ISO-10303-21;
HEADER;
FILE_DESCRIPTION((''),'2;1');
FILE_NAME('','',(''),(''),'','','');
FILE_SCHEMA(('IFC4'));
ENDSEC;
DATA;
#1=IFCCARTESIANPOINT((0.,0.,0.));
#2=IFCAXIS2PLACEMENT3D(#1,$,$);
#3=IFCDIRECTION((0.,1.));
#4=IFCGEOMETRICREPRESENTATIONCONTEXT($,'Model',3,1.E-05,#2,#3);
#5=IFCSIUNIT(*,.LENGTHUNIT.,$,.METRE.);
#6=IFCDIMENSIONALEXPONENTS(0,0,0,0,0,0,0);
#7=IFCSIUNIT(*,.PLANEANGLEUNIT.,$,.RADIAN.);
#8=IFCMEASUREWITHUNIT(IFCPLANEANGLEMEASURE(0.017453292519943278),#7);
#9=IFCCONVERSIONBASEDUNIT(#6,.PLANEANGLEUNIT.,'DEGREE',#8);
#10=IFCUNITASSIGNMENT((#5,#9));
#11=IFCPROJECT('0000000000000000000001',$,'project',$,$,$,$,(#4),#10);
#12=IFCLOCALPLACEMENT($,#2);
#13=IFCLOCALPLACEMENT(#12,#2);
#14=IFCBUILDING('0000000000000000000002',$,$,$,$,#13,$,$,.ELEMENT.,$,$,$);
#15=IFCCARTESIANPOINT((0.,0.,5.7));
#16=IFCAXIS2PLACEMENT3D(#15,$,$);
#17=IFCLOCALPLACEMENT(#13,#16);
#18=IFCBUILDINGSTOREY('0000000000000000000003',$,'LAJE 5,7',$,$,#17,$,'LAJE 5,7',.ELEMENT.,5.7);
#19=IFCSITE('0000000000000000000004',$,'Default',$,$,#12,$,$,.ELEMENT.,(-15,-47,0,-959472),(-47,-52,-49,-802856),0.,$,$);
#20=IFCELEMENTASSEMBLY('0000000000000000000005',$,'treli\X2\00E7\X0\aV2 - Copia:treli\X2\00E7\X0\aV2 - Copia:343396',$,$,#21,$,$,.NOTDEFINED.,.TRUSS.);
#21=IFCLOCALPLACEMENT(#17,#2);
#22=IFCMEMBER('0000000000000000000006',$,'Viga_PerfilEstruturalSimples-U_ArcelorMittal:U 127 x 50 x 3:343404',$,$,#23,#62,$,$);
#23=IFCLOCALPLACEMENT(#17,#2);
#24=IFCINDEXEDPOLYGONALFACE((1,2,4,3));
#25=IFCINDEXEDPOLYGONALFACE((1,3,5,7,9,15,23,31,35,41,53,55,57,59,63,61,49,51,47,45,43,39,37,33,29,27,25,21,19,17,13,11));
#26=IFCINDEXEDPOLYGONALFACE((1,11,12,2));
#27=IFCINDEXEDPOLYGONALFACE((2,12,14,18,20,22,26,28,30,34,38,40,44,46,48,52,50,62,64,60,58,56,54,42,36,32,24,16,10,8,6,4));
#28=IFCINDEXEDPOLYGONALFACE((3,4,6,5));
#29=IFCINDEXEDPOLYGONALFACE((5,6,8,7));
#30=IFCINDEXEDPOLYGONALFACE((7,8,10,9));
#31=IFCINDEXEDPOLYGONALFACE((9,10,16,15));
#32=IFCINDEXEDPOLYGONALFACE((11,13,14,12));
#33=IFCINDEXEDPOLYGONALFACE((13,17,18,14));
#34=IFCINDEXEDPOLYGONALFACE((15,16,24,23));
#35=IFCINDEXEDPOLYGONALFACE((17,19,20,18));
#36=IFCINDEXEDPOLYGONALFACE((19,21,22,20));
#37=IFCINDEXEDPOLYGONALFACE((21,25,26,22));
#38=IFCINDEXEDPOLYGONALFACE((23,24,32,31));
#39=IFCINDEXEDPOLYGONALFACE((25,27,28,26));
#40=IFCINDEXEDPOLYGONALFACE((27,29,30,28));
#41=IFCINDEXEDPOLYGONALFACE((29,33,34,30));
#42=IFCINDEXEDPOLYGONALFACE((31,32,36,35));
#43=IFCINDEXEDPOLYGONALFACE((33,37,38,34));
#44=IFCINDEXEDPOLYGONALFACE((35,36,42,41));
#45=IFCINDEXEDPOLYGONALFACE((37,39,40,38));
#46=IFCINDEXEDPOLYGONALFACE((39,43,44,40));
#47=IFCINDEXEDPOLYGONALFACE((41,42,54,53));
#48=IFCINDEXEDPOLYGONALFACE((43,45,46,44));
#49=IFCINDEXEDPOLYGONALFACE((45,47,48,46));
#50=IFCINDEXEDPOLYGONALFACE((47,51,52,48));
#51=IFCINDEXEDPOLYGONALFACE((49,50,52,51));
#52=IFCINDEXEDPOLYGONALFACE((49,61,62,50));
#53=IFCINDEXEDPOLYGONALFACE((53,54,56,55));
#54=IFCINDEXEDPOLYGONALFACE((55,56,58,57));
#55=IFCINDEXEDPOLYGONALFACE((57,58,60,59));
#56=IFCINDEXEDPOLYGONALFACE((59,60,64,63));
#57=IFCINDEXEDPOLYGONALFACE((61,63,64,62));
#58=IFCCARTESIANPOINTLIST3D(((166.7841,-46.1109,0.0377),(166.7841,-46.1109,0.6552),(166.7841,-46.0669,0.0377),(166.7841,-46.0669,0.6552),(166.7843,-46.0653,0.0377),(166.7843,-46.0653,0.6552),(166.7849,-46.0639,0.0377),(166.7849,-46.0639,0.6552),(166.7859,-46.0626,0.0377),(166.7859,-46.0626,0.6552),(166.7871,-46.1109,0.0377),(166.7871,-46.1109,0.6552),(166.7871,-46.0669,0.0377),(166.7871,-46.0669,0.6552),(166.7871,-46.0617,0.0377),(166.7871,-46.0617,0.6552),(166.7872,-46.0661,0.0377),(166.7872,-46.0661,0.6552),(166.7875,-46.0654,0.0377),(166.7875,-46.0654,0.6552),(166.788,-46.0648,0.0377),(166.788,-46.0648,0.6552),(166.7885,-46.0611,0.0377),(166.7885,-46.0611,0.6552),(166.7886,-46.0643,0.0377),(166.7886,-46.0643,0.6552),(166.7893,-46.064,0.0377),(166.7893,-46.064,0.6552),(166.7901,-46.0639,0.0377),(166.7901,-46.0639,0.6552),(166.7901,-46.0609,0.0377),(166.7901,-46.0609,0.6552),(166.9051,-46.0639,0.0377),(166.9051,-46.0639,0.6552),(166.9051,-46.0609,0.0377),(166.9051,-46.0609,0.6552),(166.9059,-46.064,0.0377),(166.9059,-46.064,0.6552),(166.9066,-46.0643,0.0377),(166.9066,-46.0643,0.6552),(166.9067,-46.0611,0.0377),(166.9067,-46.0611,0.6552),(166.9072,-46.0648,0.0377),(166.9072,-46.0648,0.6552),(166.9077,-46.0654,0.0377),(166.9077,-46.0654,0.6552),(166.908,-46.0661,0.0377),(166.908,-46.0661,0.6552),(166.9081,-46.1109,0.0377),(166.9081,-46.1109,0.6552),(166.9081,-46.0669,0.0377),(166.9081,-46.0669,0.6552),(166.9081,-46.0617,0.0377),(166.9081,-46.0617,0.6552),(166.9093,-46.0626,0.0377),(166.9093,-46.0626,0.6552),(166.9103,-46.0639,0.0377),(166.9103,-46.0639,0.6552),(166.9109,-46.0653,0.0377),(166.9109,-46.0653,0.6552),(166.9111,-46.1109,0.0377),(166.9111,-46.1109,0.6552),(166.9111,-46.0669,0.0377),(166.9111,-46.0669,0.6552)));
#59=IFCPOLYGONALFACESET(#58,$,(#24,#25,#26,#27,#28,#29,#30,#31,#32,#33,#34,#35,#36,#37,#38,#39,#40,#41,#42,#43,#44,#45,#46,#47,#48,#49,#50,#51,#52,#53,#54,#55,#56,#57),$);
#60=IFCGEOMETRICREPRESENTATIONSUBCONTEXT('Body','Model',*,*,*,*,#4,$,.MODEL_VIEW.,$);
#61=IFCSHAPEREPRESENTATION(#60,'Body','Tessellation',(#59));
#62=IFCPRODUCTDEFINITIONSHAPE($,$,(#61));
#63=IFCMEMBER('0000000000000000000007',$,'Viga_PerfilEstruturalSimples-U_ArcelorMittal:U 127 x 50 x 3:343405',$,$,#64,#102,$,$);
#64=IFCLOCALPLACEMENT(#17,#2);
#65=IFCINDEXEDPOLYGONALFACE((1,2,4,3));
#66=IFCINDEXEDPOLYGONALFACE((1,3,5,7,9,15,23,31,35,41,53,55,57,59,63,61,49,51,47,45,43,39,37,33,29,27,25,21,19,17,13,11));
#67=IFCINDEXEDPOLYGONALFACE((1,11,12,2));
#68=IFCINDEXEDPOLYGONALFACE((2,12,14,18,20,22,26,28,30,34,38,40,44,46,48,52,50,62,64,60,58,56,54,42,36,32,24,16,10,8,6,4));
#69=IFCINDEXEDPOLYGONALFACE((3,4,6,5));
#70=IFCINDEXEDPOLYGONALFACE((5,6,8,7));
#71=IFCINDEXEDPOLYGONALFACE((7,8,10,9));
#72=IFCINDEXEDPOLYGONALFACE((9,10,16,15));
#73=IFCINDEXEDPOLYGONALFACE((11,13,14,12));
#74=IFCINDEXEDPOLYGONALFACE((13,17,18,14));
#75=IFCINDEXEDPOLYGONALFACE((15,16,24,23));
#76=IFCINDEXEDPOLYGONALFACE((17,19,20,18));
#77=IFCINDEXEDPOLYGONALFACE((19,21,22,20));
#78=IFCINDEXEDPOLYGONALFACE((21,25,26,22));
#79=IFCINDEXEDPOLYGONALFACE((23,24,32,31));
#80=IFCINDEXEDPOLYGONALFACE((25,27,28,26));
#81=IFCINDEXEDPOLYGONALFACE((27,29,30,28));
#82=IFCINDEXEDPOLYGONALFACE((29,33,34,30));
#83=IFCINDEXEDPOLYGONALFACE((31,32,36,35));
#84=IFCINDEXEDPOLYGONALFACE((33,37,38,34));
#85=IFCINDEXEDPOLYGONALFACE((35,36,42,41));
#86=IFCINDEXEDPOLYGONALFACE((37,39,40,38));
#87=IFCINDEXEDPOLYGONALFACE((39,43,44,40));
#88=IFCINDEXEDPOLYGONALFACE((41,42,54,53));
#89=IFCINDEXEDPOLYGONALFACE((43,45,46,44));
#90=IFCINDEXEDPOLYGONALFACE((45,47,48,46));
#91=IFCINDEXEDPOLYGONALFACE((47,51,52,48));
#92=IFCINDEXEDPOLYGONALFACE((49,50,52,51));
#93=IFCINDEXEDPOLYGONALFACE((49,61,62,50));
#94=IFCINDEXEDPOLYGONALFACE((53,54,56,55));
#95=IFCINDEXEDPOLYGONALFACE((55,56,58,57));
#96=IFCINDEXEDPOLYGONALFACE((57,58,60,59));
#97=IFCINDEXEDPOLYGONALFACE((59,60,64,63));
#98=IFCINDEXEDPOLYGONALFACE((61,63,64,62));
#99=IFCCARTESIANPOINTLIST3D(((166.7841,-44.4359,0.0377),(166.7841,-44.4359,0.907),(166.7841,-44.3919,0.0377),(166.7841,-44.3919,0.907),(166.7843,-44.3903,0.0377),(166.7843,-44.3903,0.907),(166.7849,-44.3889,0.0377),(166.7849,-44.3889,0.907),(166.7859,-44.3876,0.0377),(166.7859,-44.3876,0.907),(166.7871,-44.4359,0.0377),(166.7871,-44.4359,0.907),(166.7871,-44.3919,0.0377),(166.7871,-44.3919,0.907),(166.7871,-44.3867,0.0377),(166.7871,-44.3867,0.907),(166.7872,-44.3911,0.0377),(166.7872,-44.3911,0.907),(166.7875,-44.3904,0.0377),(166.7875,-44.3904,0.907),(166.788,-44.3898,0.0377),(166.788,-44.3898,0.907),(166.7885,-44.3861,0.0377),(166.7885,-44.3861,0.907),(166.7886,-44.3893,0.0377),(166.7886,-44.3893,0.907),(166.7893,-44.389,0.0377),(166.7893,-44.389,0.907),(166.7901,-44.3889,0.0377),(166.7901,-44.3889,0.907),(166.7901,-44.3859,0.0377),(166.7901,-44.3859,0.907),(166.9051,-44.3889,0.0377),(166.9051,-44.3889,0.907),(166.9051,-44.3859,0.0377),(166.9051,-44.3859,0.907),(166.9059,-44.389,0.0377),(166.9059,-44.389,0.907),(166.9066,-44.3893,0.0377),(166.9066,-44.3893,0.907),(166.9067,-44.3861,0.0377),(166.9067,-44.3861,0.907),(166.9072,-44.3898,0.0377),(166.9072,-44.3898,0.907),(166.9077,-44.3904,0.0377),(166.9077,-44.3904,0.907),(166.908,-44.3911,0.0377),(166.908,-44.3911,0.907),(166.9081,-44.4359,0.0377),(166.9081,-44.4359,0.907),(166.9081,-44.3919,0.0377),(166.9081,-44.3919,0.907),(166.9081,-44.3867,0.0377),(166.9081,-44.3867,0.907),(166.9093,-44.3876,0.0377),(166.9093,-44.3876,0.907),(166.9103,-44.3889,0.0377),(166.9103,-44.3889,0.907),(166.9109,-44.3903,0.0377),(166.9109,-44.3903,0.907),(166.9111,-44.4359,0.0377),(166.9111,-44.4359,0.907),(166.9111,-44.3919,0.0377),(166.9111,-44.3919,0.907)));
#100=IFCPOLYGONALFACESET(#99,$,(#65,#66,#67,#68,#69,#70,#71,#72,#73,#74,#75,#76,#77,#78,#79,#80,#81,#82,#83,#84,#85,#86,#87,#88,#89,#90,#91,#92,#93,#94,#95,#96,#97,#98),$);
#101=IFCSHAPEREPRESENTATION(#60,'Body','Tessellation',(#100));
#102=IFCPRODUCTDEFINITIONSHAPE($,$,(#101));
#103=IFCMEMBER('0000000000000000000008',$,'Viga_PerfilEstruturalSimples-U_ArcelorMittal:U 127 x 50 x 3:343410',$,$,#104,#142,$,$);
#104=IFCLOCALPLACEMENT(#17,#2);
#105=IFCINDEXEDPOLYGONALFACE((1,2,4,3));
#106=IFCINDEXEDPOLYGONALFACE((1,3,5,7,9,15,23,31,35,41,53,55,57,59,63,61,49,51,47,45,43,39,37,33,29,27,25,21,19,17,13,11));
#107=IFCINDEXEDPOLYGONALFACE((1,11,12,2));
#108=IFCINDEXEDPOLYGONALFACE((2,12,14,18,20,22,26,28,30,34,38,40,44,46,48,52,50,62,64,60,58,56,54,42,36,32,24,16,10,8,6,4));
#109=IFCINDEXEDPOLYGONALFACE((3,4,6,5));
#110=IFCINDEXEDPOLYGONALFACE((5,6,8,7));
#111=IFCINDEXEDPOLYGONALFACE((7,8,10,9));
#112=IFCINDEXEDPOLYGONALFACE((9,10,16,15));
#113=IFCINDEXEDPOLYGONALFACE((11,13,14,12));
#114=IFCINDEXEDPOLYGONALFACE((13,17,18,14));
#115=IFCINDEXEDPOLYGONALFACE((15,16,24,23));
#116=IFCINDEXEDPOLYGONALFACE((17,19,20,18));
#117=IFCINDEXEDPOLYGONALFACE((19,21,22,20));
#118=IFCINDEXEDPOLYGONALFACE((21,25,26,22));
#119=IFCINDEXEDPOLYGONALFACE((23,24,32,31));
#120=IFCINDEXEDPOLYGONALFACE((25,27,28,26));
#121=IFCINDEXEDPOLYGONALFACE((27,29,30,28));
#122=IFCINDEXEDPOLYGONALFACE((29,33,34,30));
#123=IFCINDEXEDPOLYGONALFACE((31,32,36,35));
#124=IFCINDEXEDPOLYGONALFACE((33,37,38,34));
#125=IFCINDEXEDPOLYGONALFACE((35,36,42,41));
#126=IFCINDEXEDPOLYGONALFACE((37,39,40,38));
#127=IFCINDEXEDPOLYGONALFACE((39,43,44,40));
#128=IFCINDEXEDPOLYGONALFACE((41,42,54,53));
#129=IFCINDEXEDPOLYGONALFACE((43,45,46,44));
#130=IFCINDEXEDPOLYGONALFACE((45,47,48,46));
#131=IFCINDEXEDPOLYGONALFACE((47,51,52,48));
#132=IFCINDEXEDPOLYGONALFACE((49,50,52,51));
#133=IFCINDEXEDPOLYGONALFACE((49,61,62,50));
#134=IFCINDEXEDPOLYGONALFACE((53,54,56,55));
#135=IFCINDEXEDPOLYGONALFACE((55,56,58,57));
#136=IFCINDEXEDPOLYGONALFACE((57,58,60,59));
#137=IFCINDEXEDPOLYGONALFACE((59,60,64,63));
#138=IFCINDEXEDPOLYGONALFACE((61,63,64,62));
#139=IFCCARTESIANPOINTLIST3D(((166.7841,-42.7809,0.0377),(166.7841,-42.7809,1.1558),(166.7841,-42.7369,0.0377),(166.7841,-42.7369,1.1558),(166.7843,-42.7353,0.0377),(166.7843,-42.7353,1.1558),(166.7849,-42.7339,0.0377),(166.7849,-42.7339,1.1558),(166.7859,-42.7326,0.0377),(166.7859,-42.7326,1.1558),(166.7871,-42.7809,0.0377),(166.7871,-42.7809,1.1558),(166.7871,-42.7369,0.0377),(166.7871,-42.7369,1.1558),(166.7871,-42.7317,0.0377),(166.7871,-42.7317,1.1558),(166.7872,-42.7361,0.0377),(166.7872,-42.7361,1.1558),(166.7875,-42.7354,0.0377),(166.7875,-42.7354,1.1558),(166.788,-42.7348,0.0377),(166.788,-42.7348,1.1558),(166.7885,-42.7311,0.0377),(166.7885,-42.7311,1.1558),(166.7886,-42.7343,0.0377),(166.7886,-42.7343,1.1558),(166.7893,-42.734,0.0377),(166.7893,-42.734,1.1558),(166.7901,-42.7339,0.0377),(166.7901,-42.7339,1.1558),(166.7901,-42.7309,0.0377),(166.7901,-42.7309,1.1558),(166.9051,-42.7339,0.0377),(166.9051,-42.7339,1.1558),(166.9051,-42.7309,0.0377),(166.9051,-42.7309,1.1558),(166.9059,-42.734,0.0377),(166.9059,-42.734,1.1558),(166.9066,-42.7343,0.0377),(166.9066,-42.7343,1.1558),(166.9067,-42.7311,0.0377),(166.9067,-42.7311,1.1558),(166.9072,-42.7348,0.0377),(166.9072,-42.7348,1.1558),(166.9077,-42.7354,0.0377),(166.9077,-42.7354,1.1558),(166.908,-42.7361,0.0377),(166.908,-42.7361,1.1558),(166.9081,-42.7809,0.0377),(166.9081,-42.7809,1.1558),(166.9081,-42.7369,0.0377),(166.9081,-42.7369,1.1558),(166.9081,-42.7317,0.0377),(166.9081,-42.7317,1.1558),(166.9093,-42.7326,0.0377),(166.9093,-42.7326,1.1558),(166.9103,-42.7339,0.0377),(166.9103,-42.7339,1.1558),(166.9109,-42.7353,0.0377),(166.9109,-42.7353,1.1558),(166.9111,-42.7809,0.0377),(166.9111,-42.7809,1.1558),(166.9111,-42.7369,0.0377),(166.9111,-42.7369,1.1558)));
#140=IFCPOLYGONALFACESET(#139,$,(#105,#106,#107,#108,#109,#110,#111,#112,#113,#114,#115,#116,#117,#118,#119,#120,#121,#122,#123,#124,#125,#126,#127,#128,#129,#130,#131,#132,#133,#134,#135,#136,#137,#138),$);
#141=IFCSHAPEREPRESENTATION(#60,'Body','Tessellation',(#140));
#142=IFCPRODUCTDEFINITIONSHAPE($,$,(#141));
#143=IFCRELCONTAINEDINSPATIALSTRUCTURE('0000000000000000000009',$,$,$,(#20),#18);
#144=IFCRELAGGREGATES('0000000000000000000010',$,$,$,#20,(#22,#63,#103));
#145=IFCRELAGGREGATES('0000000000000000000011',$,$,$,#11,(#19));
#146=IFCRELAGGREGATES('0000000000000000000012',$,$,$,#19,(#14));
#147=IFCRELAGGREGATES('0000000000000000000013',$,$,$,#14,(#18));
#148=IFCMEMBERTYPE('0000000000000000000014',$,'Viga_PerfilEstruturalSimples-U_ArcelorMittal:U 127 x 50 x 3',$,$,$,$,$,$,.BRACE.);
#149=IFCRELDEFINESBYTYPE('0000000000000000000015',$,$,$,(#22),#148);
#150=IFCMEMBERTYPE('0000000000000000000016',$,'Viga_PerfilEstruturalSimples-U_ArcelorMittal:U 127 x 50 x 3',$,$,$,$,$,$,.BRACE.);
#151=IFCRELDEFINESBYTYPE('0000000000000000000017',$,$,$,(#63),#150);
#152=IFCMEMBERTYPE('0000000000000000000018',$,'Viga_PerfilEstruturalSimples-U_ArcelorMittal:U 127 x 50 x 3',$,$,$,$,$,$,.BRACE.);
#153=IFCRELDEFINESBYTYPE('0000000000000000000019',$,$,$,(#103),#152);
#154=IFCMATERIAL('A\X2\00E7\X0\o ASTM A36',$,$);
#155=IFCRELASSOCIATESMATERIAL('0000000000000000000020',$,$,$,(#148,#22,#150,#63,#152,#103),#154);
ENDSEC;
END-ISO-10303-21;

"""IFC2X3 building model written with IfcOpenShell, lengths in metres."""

from ifc_helpers import new_model, entity, si_unit, converted_unit, direction, frame, frame_2d, origin, place, context, subcontext, project, spatial, polyline, circle_curve, parameter, trimmed, segment, composite_curve, outline, extrude, source, transform, mapped, material, type_object, type_shapes, element, aggregate, save


model = new_model("IFC2X3")

# Units and contexts
model_context = context("Model", 3, precision=1e-05, world=origin(), true_north=direction((0.0, 1.0)))
body_context = subcontext(model_context, "Body", "Model", "MODEL_VIEW")
ifc_project = project(units=[si_unit("LENGTHUNIT", "METRE"), converted_unit("PLANEANGLEUNIT", "DEGREE", entity("IfcPlaneAngleMeasure", 0.017453292519943278), si_unit("PLANEANGLEUNIT", "RADIAN"), dimensions=[0, 0, 0, 0, 0, 0, 0])], contexts=[model_context])

# Site, building, storey
site_placement = place(None, origin())
site = spatial("IfcSite", under=ifc_project, at=site_placement, Name="Default", CompositionType="ELEMENT", RefLatitude=(-15, -47, 0, -959472), RefLongitude=(-47, -52, -49, -802856), RefElevation=0.0)
building_placement = place(site_placement, origin())
building = spatial("IfcBuilding", under=site, at=building_placement, CompositionType="ELEMENT")
storey_placement = place(building_placement, frame((0.0, 0.0, 5.7)))
storey = spatial("IfcBuildingStorey", under=building, at=storey_placement, Name="LAJE 5,7", LongName="LAJE 5,7", CompositionType="ELEMENT", Elevation=5.7)

# Element assembly
assembly_1_placement = place(storey_placement, origin())
assembly_1 = element("IfcElementAssembly", 1, at=assembly_1_placement, inside=storey, Name="treliçaV2 - Copia:treliçaV2 - Copia:343396", AssemblyPlace="NOTDEFINED", PredefinedType="TRUSS")
ifc_material = material(Name="Aço ASTM A36")

# Members
member_type_1 = type_object("IfcMemberType", Name="Viga_PerfilEstruturalSimples-U_ArcelorMittal:U 127 x 50 x 3", PredefinedType="BRACE", material=ifc_material)
shared_shape_1 = source(origin(), body_context, "Body", "SweptSolid", [
    extrude(outline(composite_curve([segment(polyline([(-0.0575, -0.0192), (0.0575, -0.0192)]), True, "CONTINUOUS"), segment(trimmed(circle_curve(frame_2d((0.0575, -0.0132), x_axis=(0.0, 1.0)), 0.006), [parameter(180.0)], [parameter(270.0)], True, "PARAMETER"), True, "CONTINUOUS"), segment(polyline([(0.0635, -0.0132), (0.0635, 0.0308)]), True, "CONTINUOUS"), segment(polyline([(0.0635, 0.0308), (0.0605, 0.0308)]), True, "CONTINUOUS"), segment(polyline([(0.0605, 0.0308), (0.0605, -0.0132)]), True, "CONTINUOUS"), segment(trimmed(circle_curve(frame_2d((0.0575, -0.0132), x_axis=(0.0, 1.0)), 0.003), [parameter(180.0)], [parameter(270.0)], True, "PARAMETER"), False, "CONTINUOUS"), segment(polyline([(0.0575, -0.0162), (-0.0575, -0.0162)]), True, "CONTINUOUS"), segment(trimmed(circle_curve(frame_2d((-0.0575, -0.0132), x_axis=(0.0, 1.0)), 0.003), [parameter(90.0)], [parameter(180.0)], True, "PARAMETER"), False, "CONTINUOUS"), segment(polyline([(-0.0605, -0.0132), (-0.0605, 0.0308)]), True, "CONTINUOUS"), segment(polyline([(-0.0605, 0.0308), (-0.0635, 0.0308)]), True, "CONTINUOUS"), segment(polyline([(-0.0635, 0.0308), (-0.0635, -0.0132)]), True, "CONTINUOUS"), segment(trimmed(circle_curve(frame_2d((-0.0575, -0.0132), x_axis=(0.0, 1.0)), 0.006), [parameter(90.0)], [parameter(180.0)], True, "PARAMETER"), True, "CONTINUOUS")], self_intersect=False)), frame((-0.3108, -0.0058, 0.0), z_axis=(1.0, 0.0, 0.0), x_axis=(0.0, 0.0, -1.0)), (0.0, 0.0, 1.0), 0.6175),
])
type_shapes(member_type_1, [shared_shape_1])
member_1_placement = place(assembly_1_placement, frame((166.8476, -46.0859, 0.3485), z_axis=(1.0, 0.0, 0.0), x_axis=(0.0, 0.0, 1.0)))
member_1 = element("IfcMember", 2, at=member_1_placement, type_object=member_type_1, material=ifc_material, Name="Viga_PerfilEstruturalSimples-U_ArcelorMittal:U 127 x 50 x 3:343404", context=body_context, shape_type="MappedRepresentation", body=[
    mapped(shared_shape_1, transform((0.0, 0.0, 0.0), scale=1.0)),
])
member_type_2 = type_object("IfcMemberType", Name="Viga_PerfilEstruturalSimples-U_ArcelorMittal:U 127 x 50 x 3", PredefinedType="BRACE", material=ifc_material)
shared_shape_2 = source(origin(), body_context, "Body", "SweptSolid", [
    extrude(outline(composite_curve([segment(polyline([(-0.0575, -0.0192), (0.0575, -0.0192)]), True, "CONTINUOUS"), segment(trimmed(circle_curve(frame_2d((0.0575, -0.0132), x_axis=(0.0, 1.0)), 0.006), [parameter(180.0)], [parameter(270.0)], True, "PARAMETER"), True, "CONTINUOUS"), segment(polyline([(0.0635, -0.0132), (0.0635, 0.0308)]), True, "CONTINUOUS"), segment(polyline([(0.0635, 0.0308), (0.0605, 0.0308)]), True, "CONTINUOUS"), segment(polyline([(0.0605, 0.0308), (0.0605, -0.0132)]), True, "CONTINUOUS"), segment(trimmed(circle_curve(frame_2d((0.0575, -0.0132), x_axis=(0.0, 1.0)), 0.003), [parameter(180.0)], [parameter(270.0)], True, "PARAMETER"), False, "CONTINUOUS"), segment(polyline([(0.0575, -0.0162), (-0.0575, -0.0162)]), True, "CONTINUOUS"), segment(trimmed(circle_curve(frame_2d((-0.0575, -0.0132), x_axis=(0.0, 1.0)), 0.003), [parameter(90.0)], [parameter(180.0)], True, "PARAMETER"), False, "CONTINUOUS"), segment(polyline([(-0.0605, -0.0132), (-0.0605, 0.0308)]), True, "CONTINUOUS"), segment(polyline([(-0.0605, 0.0308), (-0.0635, 0.0308)]), True, "CONTINUOUS"), segment(polyline([(-0.0635, 0.0308), (-0.0635, -0.0132)]), True, "CONTINUOUS"), segment(trimmed(circle_curve(frame_2d((-0.0575, -0.0132), x_axis=(0.0, 1.0)), 0.006), [parameter(90.0)], [parameter(180.0)], True, "PARAMETER"), True, "CONTINUOUS")], self_intersect=False)), frame((-0.4367, -0.0058, 0.0), z_axis=(1.0, 0.0, 0.0), x_axis=(0.0, 0.0, -1.0)), (0.0, 0.0, 1.0), 0.8693),
])
type_shapes(member_type_2, [shared_shape_2])
member_2_placement = place(assembly_1_placement, frame((166.8476, -44.4109, 0.4744), z_axis=(1.0, 0.0, 0.0), x_axis=(0.0, 0.0, 1.0)))
member_2 = element("IfcMember", 3, at=member_2_placement, type_object=member_type_2, material=ifc_material, Name="Viga_PerfilEstruturalSimples-U_ArcelorMittal:U 127 x 50 x 3:343405", context=body_context, shape_type="MappedRepresentation", body=[
    mapped(shared_shape_2, transform((0.0, 0.0, 0.0), scale=1.0)),
])
member_type_3 = type_object("IfcMemberType", Name="Viga_PerfilEstruturalSimples-U_ArcelorMittal:U 127 x 50 x 3", PredefinedType="BRACE", material=ifc_material)
shared_shape_3 = source(origin(), body_context, "Body", "SweptSolid", [
    extrude(outline(composite_curve([segment(polyline([(-0.0575, -0.0192), (0.0575, -0.0192)]), True, "CONTINUOUS"), segment(trimmed(circle_curve(frame_2d((0.0575, -0.0132), x_axis=(0.0, 1.0)), 0.006), [parameter(180.0)], [parameter(270.0)], True, "PARAMETER"), True, "CONTINUOUS"), segment(polyline([(0.0635, -0.0132), (0.0635, 0.0308)]), True, "CONTINUOUS"), segment(polyline([(0.0635, 0.0308), (0.0605, 0.0308)]), True, "CONTINUOUS"), segment(polyline([(0.0605, 0.0308), (0.0605, -0.0132)]), True, "CONTINUOUS"), segment(trimmed(circle_curve(frame_2d((0.0575, -0.0132), x_axis=(0.0, 1.0)), 0.003), [parameter(180.0)], [parameter(270.0)], True, "PARAMETER"), False, "CONTINUOUS"), segment(polyline([(0.0575, -0.0162), (-0.0575, -0.0162)]), True, "CONTINUOUS"), segment(trimmed(circle_curve(frame_2d((-0.0575, -0.0132), x_axis=(0.0, 1.0)), 0.003), [parameter(90.0)], [parameter(180.0)], True, "PARAMETER"), False, "CONTINUOUS"), segment(polyline([(-0.0605, -0.0132), (-0.0605, 0.0308)]), True, "CONTINUOUS"), segment(polyline([(-0.0605, 0.0308), (-0.0635, 0.0308)]), True, "CONTINUOUS"), segment(polyline([(-0.0635, 0.0308), (-0.0635, -0.0132)]), True, "CONTINUOUS"), segment(trimmed(circle_curve(frame_2d((-0.0575, -0.0132), x_axis=(0.0, 1.0)), 0.006), [parameter(90.0)], [parameter(180.0)], True, "PARAMETER"), True, "CONTINUOUS")], self_intersect=False)), frame((-0.5611, -0.0058, 0.0), z_axis=(1.0, 0.0, 0.0), x_axis=(0.0, 0.0, -1.0)), (0.0, 0.0, 1.0), 1.1181),
])
type_shapes(member_type_3, [shared_shape_3])
member_3_placement = place(assembly_1_placement, frame((166.8476, -42.7559, 0.5988), z_axis=(1.0, 0.0, 0.0), x_axis=(0.0, 0.0, 1.0)))
member_3 = element("IfcMember", 4, at=member_3_placement, type_object=member_type_3, material=ifc_material, Name="Viga_PerfilEstruturalSimples-U_ArcelorMittal:U 127 x 50 x 3:343410", context=body_context, shape_type="MappedRepresentation", body=[
    mapped(shared_shape_3, transform((0.0, 0.0, 0.0), scale=1.0)),
])
aggregate(assembly_1, [member_1, member_2, member_3])

save(model, "model.ifc")
